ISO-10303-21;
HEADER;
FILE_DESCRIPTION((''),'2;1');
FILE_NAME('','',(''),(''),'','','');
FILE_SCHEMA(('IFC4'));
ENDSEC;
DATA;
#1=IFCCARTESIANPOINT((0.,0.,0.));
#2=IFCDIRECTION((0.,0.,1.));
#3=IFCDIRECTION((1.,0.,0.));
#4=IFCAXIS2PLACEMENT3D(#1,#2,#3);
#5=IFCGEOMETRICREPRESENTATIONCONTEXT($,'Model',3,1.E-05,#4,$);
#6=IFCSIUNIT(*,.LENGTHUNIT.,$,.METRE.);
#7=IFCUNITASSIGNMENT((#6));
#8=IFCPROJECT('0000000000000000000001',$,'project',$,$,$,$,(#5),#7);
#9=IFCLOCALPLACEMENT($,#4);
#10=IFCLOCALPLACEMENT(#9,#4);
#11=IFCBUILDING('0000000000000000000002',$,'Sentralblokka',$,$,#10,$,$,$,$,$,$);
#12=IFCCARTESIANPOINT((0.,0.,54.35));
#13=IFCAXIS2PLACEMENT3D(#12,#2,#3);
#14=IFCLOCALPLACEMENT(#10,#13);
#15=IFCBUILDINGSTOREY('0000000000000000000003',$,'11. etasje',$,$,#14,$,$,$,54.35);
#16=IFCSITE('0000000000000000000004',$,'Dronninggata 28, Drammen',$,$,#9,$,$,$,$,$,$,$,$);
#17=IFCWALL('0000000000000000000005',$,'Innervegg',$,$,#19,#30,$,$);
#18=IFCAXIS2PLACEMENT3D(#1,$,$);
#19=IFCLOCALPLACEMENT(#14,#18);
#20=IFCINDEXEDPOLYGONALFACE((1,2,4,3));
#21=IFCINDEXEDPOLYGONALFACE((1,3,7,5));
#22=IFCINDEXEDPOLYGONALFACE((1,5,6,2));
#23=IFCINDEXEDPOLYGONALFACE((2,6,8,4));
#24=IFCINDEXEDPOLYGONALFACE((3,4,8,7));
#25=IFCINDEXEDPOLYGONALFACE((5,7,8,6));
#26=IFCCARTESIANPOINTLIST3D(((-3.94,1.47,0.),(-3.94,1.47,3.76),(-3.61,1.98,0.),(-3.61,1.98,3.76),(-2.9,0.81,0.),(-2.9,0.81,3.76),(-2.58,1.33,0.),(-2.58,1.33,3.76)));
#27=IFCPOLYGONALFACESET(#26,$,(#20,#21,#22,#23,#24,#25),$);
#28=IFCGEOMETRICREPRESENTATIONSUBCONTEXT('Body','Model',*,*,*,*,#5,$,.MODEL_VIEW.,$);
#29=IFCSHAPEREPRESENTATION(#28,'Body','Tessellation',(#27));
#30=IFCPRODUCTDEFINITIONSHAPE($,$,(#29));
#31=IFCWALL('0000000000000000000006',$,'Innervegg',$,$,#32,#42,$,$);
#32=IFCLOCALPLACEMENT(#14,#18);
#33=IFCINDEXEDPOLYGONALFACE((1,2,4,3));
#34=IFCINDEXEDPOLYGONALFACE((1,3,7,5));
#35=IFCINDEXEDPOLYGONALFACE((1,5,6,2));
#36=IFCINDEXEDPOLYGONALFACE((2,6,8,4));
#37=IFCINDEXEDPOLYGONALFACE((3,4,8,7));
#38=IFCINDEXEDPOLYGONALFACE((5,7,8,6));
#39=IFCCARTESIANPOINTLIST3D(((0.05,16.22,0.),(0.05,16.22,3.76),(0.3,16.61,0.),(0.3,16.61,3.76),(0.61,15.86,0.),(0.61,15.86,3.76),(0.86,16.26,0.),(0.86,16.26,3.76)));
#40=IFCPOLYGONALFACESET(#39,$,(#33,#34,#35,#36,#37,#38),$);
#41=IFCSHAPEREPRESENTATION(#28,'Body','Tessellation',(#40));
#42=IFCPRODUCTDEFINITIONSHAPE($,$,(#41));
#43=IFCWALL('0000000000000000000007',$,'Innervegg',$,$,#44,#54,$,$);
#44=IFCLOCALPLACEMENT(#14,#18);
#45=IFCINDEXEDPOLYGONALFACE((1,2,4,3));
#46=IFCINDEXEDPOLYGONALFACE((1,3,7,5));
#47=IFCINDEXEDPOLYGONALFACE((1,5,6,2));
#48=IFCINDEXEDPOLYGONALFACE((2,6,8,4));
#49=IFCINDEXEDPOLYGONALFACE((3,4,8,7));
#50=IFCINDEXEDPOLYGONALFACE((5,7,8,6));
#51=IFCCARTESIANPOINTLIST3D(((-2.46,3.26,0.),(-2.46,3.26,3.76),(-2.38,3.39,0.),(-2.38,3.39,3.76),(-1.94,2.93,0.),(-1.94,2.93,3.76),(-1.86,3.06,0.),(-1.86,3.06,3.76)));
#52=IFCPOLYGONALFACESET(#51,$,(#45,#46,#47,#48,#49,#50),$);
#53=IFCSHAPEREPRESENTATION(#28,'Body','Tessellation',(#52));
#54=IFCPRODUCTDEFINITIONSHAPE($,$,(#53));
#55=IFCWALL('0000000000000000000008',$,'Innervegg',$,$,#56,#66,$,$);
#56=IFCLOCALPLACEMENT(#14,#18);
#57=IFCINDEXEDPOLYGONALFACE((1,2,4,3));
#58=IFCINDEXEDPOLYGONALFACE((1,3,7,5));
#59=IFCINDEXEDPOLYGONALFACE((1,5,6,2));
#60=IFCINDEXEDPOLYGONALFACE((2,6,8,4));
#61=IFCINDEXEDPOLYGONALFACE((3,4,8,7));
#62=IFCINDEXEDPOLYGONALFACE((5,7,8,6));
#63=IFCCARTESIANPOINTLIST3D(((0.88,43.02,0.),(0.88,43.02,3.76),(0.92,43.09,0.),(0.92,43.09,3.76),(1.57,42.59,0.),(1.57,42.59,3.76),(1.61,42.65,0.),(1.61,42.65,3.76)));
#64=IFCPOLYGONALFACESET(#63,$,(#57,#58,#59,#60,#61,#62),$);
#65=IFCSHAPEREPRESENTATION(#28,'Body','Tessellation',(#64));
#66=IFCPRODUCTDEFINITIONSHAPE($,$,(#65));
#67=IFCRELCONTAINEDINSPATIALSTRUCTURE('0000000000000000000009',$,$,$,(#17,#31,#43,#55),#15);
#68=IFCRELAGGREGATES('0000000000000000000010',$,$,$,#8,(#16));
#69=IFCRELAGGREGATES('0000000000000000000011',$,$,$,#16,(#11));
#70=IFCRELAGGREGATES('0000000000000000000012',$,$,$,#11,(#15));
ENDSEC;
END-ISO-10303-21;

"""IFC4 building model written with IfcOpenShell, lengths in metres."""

from ifc_helpers import new_model, si_unit, frame, origin_with_axes, place, context, subcontext, project, spatial, polyline, outline, extrude, element, save


model = new_model("IFC4")

# Units and contexts
model_context = context("Model", 3, precision=1e-05, world=origin_with_axes())
body_context = subcontext(model_context, "Body", "Model", "MODEL_VIEW")
ifc_project = project(units=[si_unit("LENGTHUNIT", "METRE")], contexts=[model_context])

# Site, building, storey
site_placement = place(None, origin_with_axes())
site = spatial("IfcSite", under=ifc_project, at=site_placement, Name="Dronninggata 28, Drammen")
building_placement = place(site_placement, origin_with_axes())
building = spatial("IfcBuilding", under=site, at=building_placement, Name="Sentralblokka")
storey_placement = place(building_placement, frame((0.0, 0.0, 54.35), z_axis=(0.0, 0.0, 1.0), x_axis=(1.0, 0.0, 0.0)))
storey = spatial("IfcBuildingStorey", under=building, at=storey_placement, Name="11. etasje", Elevation=54.35)

# Walls
wall_1_placement = place(storey_placement, frame((0.0, 0.0, -54.35), z_axis=(0.0, 0.0, 1.0), x_axis=(1.0, 0.0, 0.0)))
element("IfcWall", 1, at=wall_1_placement, inside=storey, Name="Innervegg", context=body_context, shape_type="SweptSolid", body=[
    extrude(outline(polyline([(-2.58, 1.33), (-2.9, 0.81), (-3.94, 1.47), (-3.61, 1.98), (-2.58, 1.33)])), frame((0.0, 0.0, 54.35)), (0.0, 0.0, 1.0), 3.76),
])
wall_2_placement = place(storey_placement, frame((0.0, 0.0, -54.35), z_axis=(0.0, 0.0, 1.0), x_axis=(1.0, 0.0, 0.0)))
element("IfcWall", 2, at=wall_2_placement, inside=storey, Name="Innervegg", context=body_context, shape_type="SweptSolid", body=[
    extrude(outline(polyline([(0.86, 16.26), (0.61, 15.86), (0.05, 16.22), (0.3, 16.61), (0.86, 16.26)])), frame((0.0, 0.0, 54.35)), (0.0, 0.0, 1.0), 3.76),
])
wall_3_placement = place(storey_placement, frame((0.0, 0.0, -54.35), z_axis=(0.0, 0.0, 1.0), x_axis=(1.0, 0.0, 0.0)))
element("IfcWall", 3, at=wall_3_placement, inside=storey, Name="Innervegg", context=body_context, shape_type="SweptSolid", body=[
    extrude(outline(polyline([(-1.86, 3.06), (-1.94, 2.93), (-2.46, 3.26), (-2.38, 3.39), (-1.86, 3.06)])), frame((0.0, 0.0, 54.35)), (0.0, 0.0, 1.0), 3.76),
])
wall_4_placement = place(storey_placement, frame((0.0, 0.0, -54.35), z_axis=(0.0, 0.0, 1.0), x_axis=(1.0, 0.0, 0.0)))
element("IfcWall", 4, at=wall_4_placement, inside=storey, Name="Innervegg", context=body_context, shape_type="SweptSolid", body=[
    extrude(outline(polyline([(1.61, 42.65), (1.57, 42.59), (0.88, 43.02), (0.92, 43.09), (1.61, 42.65)])), frame((0.0, 0.0, 54.35)), (0.0, 0.0, 1.0), 3.76),
])

save(model, "model.ifc")
